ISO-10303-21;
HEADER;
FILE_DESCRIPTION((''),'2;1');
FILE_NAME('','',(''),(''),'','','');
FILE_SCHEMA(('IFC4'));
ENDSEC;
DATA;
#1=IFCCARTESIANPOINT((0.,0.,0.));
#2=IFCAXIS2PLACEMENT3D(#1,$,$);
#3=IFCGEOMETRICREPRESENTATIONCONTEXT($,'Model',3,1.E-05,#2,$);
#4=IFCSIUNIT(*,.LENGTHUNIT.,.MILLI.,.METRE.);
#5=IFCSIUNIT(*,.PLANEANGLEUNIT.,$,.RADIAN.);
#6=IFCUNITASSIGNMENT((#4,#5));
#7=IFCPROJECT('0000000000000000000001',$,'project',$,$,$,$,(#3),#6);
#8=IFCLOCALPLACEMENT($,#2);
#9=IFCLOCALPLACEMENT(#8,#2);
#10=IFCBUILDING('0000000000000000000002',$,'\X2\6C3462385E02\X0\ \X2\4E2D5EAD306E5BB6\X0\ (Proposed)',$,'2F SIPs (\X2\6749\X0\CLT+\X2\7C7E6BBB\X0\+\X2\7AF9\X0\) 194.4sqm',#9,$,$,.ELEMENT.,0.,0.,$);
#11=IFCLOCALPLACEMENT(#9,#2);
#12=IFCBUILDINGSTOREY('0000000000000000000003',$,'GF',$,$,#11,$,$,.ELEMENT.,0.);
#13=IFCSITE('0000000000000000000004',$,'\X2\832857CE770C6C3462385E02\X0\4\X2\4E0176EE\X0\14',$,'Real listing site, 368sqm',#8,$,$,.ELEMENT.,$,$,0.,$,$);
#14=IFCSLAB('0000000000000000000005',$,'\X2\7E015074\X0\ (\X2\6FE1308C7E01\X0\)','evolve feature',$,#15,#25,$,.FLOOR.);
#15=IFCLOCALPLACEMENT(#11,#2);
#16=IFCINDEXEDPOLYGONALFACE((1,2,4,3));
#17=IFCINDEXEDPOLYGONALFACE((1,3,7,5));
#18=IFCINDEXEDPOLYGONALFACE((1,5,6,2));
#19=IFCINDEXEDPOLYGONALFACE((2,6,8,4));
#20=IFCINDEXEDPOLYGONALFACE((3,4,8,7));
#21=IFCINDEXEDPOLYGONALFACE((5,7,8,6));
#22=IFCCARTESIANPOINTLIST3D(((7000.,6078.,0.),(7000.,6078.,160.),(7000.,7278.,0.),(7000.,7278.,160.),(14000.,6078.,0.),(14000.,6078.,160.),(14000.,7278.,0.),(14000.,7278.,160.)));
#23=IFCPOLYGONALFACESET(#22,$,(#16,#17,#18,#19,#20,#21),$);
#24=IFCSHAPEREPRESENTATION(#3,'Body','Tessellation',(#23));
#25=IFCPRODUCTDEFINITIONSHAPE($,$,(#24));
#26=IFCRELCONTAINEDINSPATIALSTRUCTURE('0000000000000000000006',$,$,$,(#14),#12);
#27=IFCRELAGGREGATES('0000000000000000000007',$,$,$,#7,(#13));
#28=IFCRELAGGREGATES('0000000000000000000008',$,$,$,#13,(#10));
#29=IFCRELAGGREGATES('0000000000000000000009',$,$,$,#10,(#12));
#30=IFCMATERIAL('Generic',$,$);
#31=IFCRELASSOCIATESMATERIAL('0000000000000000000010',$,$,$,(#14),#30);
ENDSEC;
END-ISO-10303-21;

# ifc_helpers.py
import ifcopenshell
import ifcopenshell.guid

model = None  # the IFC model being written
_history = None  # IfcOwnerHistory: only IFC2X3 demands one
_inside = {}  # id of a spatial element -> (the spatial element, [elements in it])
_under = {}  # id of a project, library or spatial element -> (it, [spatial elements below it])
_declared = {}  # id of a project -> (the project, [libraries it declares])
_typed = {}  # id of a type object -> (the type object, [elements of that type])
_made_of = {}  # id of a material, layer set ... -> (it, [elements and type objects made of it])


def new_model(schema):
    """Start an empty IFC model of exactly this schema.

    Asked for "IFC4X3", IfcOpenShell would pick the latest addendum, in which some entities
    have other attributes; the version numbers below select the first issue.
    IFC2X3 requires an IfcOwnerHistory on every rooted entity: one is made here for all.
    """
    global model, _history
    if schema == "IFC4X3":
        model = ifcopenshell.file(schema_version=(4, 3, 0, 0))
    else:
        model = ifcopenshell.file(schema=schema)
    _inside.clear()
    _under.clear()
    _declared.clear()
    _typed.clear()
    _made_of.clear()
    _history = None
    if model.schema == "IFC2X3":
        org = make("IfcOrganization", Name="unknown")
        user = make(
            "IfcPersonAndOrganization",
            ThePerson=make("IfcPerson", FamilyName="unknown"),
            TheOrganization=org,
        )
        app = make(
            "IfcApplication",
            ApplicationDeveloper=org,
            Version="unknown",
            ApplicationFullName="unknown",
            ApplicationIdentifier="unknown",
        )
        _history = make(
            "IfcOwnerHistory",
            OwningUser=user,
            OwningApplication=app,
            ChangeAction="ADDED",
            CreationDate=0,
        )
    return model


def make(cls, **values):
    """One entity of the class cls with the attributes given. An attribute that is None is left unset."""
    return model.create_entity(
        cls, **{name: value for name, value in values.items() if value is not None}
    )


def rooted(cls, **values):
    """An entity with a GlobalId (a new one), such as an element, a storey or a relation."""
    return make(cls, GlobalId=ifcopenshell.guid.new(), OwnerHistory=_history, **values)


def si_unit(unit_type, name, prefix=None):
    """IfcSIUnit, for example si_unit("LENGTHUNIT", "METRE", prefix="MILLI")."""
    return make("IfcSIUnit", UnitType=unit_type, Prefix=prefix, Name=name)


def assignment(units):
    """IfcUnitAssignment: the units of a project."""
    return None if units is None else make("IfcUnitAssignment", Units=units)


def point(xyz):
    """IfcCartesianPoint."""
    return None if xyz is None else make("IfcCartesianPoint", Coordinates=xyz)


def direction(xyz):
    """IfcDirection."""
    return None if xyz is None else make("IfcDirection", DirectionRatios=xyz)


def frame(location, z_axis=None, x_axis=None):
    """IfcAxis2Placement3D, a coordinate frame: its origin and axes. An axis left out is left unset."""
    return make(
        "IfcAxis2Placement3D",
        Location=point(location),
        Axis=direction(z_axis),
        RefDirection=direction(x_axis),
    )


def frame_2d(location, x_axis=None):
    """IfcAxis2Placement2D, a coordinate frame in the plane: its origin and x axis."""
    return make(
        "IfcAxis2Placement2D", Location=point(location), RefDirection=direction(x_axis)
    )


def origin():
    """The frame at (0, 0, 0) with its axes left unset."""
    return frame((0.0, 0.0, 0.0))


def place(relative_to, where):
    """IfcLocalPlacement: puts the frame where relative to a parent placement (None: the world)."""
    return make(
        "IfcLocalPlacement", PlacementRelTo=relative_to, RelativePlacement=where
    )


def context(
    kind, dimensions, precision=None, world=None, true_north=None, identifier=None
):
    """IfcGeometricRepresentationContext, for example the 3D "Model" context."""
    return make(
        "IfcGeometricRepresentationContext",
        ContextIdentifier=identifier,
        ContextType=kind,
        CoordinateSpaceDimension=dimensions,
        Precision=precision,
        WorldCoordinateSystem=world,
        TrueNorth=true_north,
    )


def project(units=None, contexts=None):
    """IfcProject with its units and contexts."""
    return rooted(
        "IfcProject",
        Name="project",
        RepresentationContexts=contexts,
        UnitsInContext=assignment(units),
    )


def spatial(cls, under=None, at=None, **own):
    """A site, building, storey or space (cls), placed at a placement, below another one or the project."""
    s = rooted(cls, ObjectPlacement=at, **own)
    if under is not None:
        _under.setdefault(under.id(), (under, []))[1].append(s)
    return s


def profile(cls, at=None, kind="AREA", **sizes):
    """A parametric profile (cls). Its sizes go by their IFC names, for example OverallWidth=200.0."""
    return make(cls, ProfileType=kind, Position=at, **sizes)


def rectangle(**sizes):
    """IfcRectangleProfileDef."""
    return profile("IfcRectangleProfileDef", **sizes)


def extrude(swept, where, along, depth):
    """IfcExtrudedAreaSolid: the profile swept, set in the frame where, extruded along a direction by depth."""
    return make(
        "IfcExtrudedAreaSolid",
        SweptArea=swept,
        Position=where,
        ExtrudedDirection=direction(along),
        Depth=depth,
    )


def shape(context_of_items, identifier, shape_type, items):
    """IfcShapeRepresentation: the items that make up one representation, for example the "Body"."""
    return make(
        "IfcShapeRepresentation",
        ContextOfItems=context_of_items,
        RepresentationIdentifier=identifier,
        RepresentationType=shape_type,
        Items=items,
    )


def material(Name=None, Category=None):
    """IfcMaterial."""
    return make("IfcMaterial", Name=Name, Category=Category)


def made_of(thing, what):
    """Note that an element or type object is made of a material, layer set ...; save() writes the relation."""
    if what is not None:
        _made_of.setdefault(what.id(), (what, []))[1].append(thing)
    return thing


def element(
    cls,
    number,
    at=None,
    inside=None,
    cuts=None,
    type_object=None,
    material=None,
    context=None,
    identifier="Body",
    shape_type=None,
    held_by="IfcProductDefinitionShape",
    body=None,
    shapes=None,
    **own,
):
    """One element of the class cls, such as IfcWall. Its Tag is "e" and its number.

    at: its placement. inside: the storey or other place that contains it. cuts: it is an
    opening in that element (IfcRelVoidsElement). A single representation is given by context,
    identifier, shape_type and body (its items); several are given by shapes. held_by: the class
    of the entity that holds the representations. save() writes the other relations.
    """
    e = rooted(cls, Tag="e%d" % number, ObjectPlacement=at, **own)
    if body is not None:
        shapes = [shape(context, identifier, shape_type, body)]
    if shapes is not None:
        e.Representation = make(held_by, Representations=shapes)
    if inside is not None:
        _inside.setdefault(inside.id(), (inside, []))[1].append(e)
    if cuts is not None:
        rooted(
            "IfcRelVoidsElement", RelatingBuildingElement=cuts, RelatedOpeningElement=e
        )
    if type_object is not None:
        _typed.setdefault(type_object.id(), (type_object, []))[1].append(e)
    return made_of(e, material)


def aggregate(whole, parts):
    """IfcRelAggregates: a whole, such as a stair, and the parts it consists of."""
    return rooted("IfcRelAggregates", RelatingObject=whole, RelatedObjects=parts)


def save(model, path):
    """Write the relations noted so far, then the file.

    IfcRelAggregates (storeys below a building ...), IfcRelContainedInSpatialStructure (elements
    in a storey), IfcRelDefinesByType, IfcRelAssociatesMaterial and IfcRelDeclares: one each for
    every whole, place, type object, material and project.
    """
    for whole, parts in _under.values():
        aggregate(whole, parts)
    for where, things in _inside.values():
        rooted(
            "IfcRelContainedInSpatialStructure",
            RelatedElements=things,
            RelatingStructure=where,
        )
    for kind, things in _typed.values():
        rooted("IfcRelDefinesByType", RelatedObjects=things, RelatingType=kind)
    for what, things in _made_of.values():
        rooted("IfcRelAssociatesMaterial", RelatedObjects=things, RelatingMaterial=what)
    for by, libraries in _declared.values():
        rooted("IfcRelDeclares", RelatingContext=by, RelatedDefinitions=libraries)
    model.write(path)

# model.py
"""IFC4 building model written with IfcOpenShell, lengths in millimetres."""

from ifc_helpers import new_model, si_unit, frame, frame_2d, origin, place, context, project, spatial, rectangle, extrude, material, element, save


model = new_model("IFC4")

# Units and contexts
model_context = context("Model", 3, precision=1e-05, world=origin())
ifc_project = project(units=[si_unit("LENGTHUNIT", "METRE", prefix="MILLI"), si_unit("PLANEANGLEUNIT", "RADIAN")], contexts=[model_context])

# Site, building, storey
site_placement = place(None, origin())
site = spatial("IfcSite", under=ifc_project, at=site_placement, Name="茨城県水戸市4丁目14", ObjectType="Real listing site, 368sqm", CompositionType="ELEMENT", RefElevation=0.0)
building_placement = place(site_placement, origin())
building = spatial("IfcBuilding", under=site, at=building_placement, Name="水戸市 中庭の家 (Proposed)", ObjectType="2F SIPs (杉CLT+籾殻+竹) 194.4sqm", CompositionType="ELEMENT", ElevationOfRefHeight=0.0, ElevationOfTerrain=0.0)
storey_placement = place(building_placement, origin())
storey = spatial("IfcBuildingStorey", under=building, at=storey_placement, Name="GF", CompositionType="ELEMENT", Elevation=0.0)

# Slab
ifc_material_1 = material(Name="Generic")
slab_1_placement = place(storey_placement, frame((3500.0, 3039.0, 0.0)))
element("IfcSlab", 1, at=slab_1_placement, inside=storey, material=ifc_material_1, Name="縁側 (濡れ縁)", Description="evolve feature", PredefinedType="FLOOR", context=model_context, shape_type="SweptSolid", body=[
    extrude(rectangle(XDim=7000.0, YDim=1200.0, at=frame_2d((3500.0, 600.0))), frame((3500.0, 3039.0, 0.0)), (0.0, 0.0, 1.0), 160.0),
])

save(model, "model.ifc")
